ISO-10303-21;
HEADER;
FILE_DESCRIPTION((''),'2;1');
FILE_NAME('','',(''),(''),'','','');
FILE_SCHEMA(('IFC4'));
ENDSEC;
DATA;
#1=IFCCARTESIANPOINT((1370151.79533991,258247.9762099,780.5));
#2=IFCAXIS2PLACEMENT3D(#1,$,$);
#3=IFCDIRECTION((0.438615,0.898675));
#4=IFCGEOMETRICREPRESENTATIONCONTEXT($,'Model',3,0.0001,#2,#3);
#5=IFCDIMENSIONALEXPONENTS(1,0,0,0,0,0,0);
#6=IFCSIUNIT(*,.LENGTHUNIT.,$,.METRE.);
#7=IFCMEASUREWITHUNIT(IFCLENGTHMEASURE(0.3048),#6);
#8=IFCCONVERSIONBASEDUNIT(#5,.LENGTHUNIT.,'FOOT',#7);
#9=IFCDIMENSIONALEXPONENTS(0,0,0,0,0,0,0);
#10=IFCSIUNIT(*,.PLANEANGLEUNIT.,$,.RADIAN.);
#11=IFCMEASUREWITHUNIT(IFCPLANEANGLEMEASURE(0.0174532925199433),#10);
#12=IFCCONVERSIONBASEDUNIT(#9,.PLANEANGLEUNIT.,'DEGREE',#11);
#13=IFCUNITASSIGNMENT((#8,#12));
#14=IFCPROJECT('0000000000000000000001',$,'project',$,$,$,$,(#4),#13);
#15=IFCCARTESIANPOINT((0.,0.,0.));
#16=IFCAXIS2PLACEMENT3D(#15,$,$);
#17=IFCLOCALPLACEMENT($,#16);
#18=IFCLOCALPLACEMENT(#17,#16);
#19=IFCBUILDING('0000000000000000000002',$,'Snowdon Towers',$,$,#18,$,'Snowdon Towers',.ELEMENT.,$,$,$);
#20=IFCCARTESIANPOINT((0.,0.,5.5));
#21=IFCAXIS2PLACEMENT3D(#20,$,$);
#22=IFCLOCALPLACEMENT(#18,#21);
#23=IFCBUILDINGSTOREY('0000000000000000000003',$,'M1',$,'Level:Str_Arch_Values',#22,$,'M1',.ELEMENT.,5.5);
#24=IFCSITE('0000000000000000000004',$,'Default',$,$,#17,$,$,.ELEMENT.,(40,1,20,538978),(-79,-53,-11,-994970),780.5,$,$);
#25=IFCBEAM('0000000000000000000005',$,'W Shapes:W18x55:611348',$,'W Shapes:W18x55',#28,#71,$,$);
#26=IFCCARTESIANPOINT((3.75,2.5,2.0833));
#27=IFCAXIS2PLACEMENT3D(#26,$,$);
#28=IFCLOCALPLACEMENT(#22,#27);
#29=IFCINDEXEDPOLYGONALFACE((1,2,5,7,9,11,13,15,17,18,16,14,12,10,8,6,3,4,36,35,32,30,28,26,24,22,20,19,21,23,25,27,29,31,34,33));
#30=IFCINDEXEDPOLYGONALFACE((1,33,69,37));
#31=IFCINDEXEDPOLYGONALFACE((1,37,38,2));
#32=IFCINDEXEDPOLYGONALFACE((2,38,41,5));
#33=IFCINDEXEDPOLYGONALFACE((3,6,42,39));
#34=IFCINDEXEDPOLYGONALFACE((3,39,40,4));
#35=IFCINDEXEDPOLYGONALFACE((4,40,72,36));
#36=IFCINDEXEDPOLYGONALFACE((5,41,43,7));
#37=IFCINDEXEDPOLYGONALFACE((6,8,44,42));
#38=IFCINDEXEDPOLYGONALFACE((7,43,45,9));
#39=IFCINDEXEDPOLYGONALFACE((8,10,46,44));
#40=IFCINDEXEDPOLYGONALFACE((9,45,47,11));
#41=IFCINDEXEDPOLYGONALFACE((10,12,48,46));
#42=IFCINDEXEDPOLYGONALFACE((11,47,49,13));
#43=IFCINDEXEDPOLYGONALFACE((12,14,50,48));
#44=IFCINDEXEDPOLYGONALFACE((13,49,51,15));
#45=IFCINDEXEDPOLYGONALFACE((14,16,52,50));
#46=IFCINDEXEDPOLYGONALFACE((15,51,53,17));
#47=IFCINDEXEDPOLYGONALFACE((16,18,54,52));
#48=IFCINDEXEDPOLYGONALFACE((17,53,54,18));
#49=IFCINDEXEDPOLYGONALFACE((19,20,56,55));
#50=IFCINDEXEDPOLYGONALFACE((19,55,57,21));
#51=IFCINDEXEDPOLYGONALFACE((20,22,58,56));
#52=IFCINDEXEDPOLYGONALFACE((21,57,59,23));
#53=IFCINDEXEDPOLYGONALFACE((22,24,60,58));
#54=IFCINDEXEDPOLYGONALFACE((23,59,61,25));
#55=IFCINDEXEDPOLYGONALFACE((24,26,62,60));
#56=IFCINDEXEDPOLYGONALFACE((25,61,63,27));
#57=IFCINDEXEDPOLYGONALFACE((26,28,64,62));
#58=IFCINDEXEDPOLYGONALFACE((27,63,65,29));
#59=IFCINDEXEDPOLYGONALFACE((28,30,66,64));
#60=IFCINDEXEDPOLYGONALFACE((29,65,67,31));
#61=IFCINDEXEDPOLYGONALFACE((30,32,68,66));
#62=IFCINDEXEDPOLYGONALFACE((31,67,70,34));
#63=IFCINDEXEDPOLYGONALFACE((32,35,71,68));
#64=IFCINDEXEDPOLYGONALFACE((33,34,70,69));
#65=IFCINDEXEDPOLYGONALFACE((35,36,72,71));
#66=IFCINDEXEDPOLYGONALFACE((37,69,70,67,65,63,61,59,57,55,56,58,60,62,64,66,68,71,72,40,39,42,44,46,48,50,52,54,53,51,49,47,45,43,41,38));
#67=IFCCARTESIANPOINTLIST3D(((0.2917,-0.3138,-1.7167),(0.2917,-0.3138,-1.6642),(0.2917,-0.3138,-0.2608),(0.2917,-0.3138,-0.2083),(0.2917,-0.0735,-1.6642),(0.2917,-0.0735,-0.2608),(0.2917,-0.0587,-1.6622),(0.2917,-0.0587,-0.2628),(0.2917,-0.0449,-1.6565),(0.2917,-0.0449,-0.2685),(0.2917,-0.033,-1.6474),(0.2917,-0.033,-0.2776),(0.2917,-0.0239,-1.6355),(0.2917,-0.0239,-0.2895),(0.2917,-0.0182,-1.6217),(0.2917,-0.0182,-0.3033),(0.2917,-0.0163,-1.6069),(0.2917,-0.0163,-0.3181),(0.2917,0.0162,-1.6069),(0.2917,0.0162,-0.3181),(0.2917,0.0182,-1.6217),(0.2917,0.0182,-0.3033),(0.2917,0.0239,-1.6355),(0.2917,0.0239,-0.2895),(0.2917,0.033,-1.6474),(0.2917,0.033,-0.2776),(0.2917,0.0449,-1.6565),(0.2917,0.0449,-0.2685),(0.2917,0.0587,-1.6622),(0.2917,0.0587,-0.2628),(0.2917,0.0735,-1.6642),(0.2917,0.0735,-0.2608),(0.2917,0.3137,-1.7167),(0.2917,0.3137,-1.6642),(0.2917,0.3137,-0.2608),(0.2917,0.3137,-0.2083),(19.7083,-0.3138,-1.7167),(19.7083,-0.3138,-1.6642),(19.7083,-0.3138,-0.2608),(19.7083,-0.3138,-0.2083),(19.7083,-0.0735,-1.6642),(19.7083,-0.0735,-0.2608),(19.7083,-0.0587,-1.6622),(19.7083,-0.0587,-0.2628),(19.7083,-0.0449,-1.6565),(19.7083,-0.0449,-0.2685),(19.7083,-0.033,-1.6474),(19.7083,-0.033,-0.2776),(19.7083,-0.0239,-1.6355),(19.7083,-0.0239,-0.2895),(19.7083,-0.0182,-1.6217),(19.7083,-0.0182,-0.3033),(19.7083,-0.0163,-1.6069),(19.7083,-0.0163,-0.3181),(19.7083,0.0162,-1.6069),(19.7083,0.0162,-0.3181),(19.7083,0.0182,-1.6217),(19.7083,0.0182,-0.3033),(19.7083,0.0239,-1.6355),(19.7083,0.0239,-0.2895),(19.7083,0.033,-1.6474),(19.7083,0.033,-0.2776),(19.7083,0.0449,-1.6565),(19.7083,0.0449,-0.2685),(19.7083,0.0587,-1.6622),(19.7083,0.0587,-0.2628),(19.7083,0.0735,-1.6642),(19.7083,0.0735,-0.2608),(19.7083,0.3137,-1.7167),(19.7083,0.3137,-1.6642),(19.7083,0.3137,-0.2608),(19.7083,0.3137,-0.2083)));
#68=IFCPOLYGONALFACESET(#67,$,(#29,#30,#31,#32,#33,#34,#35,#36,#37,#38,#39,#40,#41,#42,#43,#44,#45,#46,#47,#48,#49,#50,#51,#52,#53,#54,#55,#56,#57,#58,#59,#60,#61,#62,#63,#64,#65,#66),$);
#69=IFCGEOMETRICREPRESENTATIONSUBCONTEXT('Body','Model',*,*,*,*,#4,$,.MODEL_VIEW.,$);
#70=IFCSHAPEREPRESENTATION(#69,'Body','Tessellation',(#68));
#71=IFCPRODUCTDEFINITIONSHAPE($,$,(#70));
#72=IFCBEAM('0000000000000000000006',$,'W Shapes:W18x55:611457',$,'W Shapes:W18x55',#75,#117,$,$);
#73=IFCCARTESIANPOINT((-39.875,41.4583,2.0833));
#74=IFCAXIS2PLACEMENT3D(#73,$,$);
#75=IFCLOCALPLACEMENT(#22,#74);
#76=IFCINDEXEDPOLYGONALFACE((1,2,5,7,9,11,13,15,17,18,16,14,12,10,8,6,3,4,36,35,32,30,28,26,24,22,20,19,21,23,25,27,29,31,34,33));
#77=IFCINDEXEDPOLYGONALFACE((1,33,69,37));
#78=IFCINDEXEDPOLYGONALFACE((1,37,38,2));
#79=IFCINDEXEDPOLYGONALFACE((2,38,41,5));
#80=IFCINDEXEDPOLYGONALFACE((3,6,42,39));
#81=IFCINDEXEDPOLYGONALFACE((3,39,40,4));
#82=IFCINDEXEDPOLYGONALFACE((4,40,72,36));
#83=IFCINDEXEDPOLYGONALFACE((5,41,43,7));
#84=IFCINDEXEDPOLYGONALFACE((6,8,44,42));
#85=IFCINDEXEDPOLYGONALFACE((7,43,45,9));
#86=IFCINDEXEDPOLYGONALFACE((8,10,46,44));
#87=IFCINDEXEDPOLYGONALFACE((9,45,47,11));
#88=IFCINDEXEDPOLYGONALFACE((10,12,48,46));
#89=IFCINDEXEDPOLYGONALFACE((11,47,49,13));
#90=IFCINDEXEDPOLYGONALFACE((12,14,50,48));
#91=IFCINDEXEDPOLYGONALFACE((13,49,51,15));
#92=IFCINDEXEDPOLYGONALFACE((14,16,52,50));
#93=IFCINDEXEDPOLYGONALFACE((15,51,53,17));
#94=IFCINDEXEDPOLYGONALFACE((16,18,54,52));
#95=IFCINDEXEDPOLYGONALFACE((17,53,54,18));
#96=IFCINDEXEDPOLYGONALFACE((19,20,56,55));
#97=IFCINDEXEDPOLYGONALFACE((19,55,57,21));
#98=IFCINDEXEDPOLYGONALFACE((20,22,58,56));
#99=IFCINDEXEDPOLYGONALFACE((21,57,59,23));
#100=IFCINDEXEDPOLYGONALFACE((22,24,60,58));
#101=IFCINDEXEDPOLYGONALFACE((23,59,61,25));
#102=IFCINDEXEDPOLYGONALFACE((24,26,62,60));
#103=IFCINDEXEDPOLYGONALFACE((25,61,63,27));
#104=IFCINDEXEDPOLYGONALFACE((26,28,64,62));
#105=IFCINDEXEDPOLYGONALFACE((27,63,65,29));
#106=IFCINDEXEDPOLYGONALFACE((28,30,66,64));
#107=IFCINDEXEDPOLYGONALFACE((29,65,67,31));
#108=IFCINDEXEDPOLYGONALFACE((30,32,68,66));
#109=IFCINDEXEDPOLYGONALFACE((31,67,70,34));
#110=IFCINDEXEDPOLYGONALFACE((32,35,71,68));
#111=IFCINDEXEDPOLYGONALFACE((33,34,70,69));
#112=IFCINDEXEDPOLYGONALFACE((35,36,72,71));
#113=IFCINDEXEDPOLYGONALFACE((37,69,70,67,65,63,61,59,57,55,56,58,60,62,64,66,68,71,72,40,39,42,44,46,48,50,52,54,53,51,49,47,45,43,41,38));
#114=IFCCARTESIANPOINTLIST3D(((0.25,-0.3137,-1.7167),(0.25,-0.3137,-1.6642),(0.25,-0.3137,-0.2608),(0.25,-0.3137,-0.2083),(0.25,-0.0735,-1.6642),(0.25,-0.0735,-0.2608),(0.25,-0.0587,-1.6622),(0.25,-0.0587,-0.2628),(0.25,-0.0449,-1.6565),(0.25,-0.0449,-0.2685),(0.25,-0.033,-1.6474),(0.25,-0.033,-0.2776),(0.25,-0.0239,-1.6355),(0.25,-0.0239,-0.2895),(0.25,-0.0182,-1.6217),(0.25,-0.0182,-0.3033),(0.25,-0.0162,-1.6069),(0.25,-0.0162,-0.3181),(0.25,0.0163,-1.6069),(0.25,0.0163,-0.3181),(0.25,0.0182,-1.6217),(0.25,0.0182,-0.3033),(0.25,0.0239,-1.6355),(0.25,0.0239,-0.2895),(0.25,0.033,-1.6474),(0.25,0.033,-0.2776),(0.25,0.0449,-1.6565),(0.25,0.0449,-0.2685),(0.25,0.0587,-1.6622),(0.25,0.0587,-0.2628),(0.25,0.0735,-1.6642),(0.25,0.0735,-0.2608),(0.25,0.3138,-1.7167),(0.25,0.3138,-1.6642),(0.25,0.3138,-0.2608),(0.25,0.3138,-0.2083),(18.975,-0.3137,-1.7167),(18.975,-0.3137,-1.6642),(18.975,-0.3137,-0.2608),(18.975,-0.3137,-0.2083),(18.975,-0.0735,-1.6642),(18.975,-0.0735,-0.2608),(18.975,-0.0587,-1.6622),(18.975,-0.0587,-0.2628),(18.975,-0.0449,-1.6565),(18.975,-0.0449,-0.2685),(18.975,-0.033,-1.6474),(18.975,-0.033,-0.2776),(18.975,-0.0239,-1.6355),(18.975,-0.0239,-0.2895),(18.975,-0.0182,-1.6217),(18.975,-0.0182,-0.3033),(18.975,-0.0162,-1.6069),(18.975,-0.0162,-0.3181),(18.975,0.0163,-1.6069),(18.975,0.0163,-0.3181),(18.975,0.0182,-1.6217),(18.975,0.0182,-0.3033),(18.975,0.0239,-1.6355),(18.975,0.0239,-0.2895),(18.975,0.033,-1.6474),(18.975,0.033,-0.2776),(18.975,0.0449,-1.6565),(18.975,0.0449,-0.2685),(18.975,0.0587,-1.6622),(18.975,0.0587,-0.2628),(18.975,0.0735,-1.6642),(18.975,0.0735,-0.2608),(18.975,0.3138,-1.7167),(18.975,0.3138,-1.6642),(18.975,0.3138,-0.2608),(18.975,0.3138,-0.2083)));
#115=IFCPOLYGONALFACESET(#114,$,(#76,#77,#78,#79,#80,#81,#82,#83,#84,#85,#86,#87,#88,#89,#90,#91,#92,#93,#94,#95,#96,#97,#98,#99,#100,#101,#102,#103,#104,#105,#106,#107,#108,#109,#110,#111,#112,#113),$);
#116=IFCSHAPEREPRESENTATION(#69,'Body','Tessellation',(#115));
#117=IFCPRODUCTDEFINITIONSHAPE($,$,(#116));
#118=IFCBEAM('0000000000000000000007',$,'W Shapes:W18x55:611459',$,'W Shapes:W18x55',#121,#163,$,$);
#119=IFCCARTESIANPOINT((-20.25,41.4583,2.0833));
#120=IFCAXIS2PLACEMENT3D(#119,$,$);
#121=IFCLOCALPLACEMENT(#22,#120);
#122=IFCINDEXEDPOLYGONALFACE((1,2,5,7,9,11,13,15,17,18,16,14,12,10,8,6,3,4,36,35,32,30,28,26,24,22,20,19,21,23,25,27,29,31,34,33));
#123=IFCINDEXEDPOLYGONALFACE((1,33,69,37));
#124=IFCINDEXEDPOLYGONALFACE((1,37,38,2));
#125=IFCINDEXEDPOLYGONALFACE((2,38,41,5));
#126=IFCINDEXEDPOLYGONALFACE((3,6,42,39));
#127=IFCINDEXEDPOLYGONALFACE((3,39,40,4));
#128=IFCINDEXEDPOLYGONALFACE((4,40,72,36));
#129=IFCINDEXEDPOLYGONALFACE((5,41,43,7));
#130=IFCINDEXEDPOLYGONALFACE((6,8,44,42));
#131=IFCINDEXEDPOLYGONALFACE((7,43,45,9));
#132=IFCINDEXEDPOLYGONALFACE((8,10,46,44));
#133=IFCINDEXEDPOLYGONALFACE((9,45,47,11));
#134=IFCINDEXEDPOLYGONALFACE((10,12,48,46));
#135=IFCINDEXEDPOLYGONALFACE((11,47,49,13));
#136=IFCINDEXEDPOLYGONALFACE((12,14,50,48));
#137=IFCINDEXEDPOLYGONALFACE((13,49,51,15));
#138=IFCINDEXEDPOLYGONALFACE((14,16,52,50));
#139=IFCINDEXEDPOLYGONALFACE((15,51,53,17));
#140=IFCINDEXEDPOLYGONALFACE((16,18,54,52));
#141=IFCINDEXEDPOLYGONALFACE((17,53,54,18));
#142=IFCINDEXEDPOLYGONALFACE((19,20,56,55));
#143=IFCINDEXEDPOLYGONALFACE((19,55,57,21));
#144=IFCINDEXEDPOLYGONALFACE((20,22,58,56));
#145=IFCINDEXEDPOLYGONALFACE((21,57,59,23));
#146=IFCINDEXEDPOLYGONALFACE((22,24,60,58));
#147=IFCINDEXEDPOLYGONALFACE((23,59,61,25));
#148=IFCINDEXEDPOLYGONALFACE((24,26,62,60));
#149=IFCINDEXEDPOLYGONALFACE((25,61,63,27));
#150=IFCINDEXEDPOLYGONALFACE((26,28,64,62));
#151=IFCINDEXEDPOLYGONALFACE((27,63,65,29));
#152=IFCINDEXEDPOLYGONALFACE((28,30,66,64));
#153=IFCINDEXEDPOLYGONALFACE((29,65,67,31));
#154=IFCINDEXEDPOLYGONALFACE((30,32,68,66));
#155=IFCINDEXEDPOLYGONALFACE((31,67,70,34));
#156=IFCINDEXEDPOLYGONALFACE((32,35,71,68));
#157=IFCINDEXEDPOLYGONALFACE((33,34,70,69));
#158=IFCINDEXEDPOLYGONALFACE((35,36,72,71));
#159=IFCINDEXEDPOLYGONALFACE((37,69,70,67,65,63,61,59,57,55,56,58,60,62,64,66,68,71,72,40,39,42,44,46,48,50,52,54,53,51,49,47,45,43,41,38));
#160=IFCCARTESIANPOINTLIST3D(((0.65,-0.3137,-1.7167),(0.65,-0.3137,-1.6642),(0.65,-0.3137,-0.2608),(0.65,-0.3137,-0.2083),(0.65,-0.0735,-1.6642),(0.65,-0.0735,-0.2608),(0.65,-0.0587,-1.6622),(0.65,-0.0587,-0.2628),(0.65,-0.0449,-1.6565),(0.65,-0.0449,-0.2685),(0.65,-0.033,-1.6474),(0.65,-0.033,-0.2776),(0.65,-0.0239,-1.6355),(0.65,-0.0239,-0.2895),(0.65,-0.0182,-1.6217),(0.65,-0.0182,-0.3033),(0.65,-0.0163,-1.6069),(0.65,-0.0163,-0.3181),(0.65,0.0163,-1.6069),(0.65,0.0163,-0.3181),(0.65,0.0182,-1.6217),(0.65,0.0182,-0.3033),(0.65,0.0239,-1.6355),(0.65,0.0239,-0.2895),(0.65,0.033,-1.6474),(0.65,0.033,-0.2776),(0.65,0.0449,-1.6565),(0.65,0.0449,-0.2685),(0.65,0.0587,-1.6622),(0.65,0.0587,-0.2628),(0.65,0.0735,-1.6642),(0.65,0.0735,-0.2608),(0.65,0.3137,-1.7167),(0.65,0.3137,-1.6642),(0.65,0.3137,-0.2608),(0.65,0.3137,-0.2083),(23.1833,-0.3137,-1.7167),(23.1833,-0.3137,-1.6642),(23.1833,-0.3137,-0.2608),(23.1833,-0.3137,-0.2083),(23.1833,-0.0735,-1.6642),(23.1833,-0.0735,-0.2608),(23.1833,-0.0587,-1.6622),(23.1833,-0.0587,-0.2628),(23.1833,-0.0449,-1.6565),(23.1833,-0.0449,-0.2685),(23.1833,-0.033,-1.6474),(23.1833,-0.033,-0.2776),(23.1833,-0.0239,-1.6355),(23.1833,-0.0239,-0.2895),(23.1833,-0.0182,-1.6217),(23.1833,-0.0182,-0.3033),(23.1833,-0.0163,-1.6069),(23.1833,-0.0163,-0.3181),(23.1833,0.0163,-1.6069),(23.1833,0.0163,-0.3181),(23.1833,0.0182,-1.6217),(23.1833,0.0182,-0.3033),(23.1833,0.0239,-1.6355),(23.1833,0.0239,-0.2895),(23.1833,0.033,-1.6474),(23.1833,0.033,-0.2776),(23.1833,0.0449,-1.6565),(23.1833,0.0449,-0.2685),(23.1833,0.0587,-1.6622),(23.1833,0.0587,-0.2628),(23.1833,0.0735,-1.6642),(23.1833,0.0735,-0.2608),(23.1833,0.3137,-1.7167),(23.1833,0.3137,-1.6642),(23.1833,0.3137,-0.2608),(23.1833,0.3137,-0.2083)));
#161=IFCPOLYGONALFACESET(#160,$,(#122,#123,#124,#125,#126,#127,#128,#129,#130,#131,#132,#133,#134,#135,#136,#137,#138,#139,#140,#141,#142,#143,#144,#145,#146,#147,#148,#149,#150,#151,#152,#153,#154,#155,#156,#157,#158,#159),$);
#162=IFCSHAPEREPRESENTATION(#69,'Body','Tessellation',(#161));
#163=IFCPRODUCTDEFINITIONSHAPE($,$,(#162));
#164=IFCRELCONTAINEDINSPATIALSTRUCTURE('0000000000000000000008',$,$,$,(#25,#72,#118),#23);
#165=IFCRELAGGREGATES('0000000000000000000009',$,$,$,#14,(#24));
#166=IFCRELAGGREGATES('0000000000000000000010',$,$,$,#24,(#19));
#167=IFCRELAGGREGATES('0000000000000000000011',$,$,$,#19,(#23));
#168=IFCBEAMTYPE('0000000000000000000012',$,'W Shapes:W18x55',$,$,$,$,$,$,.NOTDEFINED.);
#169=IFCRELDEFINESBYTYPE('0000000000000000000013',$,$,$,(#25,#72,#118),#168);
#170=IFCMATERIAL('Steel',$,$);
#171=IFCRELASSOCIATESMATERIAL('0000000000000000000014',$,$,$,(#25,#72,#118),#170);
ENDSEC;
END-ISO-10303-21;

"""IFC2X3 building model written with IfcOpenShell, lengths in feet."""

from ifc_helpers import new_model, entity, si_unit, converted_unit, direction, frame, frame_2d, origin, place, context, subcontext, project, spatial, i_section, extrude, material, type_object, element, save


model = new_model("IFC2X3")

# Units and contexts
model_context = context("Model", 3, precision=0.0001, world=frame((1370151.79533991, 258247.9762099, 780.5)), true_north=direction((0.438615, 0.898675)))
body_context = subcontext(model_context, "Body", "Model", "MODEL_VIEW")
ifc_project = project(units=[converted_unit("LENGTHUNIT", "FOOT", entity("IfcLengthMeasure", 0.3048), si_unit("LENGTHUNIT", "METRE"), dimensions=[1, 0, 0, 0, 0, 0, 0]), converted_unit("PLANEANGLEUNIT", "DEGREE", entity("IfcPlaneAngleMeasure", 0.0174532925199433), si_unit("PLANEANGLEUNIT", "RADIAN"), dimensions=[0, 0, 0, 0, 0, 0, 0])], contexts=[model_context])

# Site, building, storey
site_placement = place(None, origin())
site = spatial("IfcSite", under=ifc_project, at=site_placement, Name="Default", CompositionType="ELEMENT", RefLatitude=(40, 1, 20, 538978), RefLongitude=(-79, -53, -11, -994970), RefElevation=780.5)
building_placement = place(site_placement, origin())
building = spatial("IfcBuilding", under=site, at=building_placement, Name="Snowdon Towers", LongName="Snowdon Towers", CompositionType="ELEMENT")
storey_placement = place(building_placement, frame((0.0, 0.0, 5.5)))
storey = spatial("IfcBuildingStorey", under=building, at=storey_placement, Name="M1", ObjectType="Level:Str_Arch_Values", LongName="M1", CompositionType="ELEMENT", Elevation=5.5)

# Beams
ifc_material_1 = material(Name="Steel")
beam_type_1 = type_object("IfcBeamType", Name="W Shapes:W18x55", PredefinedType="NOTDEFINED")
beam_1_placement = place(storey_placement, frame((3.75, 2.5, 2.0833)))
element("IfcBeam", 1, at=beam_1_placement, inside=storey, type_object=beam_type_1, material=ifc_material_1, Name="W Shapes:W18x55:611348", ObjectType="W Shapes:W18x55", context=body_context, shape_type="SweptSolid", body=[
    extrude(i_section(OverallWidth=0.6275, OverallDepth=1.5083, WebThickness=0.0325, FlangeThickness=0.0525, FilletRadius=0.0573, at=frame_2d((0.0, 0.0), x_axis=(0.0, 1.0))), frame((0.2917, 0.0, -0.9625), z_axis=(1.0, 0.0, 0.0), x_axis=(0.0, 0.0, -1.0)), (0.0, 0.0, 1.0), 19.4167),
])
beam_2_placement = place(storey_placement, frame((-39.875, 41.4583, 2.0833)))
element("IfcBeam", 2, at=beam_2_placement, inside=storey, type_object=beam_type_1, material=ifc_material_1, Name="W Shapes:W18x55:611457", ObjectType="W Shapes:W18x55", context=body_context, shape_type="SweptSolid", body=[
    extrude(i_section(OverallWidth=0.6275, OverallDepth=1.5083, WebThickness=0.0325, FlangeThickness=0.0525, FilletRadius=0.0573, at=frame_2d((0.0, 0.0), x_axis=(0.0, 1.0))), frame((0.25, 0.0, -0.9625), z_axis=(1.0, 0.0, 0.0), x_axis=(0.0, 0.0, -1.0)), (0.0, 0.0, 1.0), 18.725),
])
beam_3_placement = place(storey_placement, frame((-20.25, 41.4583, 2.0833)))
element("IfcBeam", 3, at=beam_3_placement, inside=storey, type_object=beam_type_1, material=ifc_material_1, Name="W Shapes:W18x55:611459", ObjectType="W Shapes:W18x55", context=body_context, shape_type="SweptSolid", body=[
    extrude(i_section(OverallWidth=0.6275, OverallDepth=1.5083, WebThickness=0.0325, FlangeThickness=0.0525, FilletRadius=0.0573, at=frame_2d((0.0, 0.0), x_axis=(0.0, 1.0))), frame((0.65, 0.0, -0.9625), z_axis=(1.0, 0.0, 0.0), x_axis=(0.0, 0.0, -1.0)), (0.0, 0.0, 1.0), 22.5333),
])

save(model, "model.ifc")
